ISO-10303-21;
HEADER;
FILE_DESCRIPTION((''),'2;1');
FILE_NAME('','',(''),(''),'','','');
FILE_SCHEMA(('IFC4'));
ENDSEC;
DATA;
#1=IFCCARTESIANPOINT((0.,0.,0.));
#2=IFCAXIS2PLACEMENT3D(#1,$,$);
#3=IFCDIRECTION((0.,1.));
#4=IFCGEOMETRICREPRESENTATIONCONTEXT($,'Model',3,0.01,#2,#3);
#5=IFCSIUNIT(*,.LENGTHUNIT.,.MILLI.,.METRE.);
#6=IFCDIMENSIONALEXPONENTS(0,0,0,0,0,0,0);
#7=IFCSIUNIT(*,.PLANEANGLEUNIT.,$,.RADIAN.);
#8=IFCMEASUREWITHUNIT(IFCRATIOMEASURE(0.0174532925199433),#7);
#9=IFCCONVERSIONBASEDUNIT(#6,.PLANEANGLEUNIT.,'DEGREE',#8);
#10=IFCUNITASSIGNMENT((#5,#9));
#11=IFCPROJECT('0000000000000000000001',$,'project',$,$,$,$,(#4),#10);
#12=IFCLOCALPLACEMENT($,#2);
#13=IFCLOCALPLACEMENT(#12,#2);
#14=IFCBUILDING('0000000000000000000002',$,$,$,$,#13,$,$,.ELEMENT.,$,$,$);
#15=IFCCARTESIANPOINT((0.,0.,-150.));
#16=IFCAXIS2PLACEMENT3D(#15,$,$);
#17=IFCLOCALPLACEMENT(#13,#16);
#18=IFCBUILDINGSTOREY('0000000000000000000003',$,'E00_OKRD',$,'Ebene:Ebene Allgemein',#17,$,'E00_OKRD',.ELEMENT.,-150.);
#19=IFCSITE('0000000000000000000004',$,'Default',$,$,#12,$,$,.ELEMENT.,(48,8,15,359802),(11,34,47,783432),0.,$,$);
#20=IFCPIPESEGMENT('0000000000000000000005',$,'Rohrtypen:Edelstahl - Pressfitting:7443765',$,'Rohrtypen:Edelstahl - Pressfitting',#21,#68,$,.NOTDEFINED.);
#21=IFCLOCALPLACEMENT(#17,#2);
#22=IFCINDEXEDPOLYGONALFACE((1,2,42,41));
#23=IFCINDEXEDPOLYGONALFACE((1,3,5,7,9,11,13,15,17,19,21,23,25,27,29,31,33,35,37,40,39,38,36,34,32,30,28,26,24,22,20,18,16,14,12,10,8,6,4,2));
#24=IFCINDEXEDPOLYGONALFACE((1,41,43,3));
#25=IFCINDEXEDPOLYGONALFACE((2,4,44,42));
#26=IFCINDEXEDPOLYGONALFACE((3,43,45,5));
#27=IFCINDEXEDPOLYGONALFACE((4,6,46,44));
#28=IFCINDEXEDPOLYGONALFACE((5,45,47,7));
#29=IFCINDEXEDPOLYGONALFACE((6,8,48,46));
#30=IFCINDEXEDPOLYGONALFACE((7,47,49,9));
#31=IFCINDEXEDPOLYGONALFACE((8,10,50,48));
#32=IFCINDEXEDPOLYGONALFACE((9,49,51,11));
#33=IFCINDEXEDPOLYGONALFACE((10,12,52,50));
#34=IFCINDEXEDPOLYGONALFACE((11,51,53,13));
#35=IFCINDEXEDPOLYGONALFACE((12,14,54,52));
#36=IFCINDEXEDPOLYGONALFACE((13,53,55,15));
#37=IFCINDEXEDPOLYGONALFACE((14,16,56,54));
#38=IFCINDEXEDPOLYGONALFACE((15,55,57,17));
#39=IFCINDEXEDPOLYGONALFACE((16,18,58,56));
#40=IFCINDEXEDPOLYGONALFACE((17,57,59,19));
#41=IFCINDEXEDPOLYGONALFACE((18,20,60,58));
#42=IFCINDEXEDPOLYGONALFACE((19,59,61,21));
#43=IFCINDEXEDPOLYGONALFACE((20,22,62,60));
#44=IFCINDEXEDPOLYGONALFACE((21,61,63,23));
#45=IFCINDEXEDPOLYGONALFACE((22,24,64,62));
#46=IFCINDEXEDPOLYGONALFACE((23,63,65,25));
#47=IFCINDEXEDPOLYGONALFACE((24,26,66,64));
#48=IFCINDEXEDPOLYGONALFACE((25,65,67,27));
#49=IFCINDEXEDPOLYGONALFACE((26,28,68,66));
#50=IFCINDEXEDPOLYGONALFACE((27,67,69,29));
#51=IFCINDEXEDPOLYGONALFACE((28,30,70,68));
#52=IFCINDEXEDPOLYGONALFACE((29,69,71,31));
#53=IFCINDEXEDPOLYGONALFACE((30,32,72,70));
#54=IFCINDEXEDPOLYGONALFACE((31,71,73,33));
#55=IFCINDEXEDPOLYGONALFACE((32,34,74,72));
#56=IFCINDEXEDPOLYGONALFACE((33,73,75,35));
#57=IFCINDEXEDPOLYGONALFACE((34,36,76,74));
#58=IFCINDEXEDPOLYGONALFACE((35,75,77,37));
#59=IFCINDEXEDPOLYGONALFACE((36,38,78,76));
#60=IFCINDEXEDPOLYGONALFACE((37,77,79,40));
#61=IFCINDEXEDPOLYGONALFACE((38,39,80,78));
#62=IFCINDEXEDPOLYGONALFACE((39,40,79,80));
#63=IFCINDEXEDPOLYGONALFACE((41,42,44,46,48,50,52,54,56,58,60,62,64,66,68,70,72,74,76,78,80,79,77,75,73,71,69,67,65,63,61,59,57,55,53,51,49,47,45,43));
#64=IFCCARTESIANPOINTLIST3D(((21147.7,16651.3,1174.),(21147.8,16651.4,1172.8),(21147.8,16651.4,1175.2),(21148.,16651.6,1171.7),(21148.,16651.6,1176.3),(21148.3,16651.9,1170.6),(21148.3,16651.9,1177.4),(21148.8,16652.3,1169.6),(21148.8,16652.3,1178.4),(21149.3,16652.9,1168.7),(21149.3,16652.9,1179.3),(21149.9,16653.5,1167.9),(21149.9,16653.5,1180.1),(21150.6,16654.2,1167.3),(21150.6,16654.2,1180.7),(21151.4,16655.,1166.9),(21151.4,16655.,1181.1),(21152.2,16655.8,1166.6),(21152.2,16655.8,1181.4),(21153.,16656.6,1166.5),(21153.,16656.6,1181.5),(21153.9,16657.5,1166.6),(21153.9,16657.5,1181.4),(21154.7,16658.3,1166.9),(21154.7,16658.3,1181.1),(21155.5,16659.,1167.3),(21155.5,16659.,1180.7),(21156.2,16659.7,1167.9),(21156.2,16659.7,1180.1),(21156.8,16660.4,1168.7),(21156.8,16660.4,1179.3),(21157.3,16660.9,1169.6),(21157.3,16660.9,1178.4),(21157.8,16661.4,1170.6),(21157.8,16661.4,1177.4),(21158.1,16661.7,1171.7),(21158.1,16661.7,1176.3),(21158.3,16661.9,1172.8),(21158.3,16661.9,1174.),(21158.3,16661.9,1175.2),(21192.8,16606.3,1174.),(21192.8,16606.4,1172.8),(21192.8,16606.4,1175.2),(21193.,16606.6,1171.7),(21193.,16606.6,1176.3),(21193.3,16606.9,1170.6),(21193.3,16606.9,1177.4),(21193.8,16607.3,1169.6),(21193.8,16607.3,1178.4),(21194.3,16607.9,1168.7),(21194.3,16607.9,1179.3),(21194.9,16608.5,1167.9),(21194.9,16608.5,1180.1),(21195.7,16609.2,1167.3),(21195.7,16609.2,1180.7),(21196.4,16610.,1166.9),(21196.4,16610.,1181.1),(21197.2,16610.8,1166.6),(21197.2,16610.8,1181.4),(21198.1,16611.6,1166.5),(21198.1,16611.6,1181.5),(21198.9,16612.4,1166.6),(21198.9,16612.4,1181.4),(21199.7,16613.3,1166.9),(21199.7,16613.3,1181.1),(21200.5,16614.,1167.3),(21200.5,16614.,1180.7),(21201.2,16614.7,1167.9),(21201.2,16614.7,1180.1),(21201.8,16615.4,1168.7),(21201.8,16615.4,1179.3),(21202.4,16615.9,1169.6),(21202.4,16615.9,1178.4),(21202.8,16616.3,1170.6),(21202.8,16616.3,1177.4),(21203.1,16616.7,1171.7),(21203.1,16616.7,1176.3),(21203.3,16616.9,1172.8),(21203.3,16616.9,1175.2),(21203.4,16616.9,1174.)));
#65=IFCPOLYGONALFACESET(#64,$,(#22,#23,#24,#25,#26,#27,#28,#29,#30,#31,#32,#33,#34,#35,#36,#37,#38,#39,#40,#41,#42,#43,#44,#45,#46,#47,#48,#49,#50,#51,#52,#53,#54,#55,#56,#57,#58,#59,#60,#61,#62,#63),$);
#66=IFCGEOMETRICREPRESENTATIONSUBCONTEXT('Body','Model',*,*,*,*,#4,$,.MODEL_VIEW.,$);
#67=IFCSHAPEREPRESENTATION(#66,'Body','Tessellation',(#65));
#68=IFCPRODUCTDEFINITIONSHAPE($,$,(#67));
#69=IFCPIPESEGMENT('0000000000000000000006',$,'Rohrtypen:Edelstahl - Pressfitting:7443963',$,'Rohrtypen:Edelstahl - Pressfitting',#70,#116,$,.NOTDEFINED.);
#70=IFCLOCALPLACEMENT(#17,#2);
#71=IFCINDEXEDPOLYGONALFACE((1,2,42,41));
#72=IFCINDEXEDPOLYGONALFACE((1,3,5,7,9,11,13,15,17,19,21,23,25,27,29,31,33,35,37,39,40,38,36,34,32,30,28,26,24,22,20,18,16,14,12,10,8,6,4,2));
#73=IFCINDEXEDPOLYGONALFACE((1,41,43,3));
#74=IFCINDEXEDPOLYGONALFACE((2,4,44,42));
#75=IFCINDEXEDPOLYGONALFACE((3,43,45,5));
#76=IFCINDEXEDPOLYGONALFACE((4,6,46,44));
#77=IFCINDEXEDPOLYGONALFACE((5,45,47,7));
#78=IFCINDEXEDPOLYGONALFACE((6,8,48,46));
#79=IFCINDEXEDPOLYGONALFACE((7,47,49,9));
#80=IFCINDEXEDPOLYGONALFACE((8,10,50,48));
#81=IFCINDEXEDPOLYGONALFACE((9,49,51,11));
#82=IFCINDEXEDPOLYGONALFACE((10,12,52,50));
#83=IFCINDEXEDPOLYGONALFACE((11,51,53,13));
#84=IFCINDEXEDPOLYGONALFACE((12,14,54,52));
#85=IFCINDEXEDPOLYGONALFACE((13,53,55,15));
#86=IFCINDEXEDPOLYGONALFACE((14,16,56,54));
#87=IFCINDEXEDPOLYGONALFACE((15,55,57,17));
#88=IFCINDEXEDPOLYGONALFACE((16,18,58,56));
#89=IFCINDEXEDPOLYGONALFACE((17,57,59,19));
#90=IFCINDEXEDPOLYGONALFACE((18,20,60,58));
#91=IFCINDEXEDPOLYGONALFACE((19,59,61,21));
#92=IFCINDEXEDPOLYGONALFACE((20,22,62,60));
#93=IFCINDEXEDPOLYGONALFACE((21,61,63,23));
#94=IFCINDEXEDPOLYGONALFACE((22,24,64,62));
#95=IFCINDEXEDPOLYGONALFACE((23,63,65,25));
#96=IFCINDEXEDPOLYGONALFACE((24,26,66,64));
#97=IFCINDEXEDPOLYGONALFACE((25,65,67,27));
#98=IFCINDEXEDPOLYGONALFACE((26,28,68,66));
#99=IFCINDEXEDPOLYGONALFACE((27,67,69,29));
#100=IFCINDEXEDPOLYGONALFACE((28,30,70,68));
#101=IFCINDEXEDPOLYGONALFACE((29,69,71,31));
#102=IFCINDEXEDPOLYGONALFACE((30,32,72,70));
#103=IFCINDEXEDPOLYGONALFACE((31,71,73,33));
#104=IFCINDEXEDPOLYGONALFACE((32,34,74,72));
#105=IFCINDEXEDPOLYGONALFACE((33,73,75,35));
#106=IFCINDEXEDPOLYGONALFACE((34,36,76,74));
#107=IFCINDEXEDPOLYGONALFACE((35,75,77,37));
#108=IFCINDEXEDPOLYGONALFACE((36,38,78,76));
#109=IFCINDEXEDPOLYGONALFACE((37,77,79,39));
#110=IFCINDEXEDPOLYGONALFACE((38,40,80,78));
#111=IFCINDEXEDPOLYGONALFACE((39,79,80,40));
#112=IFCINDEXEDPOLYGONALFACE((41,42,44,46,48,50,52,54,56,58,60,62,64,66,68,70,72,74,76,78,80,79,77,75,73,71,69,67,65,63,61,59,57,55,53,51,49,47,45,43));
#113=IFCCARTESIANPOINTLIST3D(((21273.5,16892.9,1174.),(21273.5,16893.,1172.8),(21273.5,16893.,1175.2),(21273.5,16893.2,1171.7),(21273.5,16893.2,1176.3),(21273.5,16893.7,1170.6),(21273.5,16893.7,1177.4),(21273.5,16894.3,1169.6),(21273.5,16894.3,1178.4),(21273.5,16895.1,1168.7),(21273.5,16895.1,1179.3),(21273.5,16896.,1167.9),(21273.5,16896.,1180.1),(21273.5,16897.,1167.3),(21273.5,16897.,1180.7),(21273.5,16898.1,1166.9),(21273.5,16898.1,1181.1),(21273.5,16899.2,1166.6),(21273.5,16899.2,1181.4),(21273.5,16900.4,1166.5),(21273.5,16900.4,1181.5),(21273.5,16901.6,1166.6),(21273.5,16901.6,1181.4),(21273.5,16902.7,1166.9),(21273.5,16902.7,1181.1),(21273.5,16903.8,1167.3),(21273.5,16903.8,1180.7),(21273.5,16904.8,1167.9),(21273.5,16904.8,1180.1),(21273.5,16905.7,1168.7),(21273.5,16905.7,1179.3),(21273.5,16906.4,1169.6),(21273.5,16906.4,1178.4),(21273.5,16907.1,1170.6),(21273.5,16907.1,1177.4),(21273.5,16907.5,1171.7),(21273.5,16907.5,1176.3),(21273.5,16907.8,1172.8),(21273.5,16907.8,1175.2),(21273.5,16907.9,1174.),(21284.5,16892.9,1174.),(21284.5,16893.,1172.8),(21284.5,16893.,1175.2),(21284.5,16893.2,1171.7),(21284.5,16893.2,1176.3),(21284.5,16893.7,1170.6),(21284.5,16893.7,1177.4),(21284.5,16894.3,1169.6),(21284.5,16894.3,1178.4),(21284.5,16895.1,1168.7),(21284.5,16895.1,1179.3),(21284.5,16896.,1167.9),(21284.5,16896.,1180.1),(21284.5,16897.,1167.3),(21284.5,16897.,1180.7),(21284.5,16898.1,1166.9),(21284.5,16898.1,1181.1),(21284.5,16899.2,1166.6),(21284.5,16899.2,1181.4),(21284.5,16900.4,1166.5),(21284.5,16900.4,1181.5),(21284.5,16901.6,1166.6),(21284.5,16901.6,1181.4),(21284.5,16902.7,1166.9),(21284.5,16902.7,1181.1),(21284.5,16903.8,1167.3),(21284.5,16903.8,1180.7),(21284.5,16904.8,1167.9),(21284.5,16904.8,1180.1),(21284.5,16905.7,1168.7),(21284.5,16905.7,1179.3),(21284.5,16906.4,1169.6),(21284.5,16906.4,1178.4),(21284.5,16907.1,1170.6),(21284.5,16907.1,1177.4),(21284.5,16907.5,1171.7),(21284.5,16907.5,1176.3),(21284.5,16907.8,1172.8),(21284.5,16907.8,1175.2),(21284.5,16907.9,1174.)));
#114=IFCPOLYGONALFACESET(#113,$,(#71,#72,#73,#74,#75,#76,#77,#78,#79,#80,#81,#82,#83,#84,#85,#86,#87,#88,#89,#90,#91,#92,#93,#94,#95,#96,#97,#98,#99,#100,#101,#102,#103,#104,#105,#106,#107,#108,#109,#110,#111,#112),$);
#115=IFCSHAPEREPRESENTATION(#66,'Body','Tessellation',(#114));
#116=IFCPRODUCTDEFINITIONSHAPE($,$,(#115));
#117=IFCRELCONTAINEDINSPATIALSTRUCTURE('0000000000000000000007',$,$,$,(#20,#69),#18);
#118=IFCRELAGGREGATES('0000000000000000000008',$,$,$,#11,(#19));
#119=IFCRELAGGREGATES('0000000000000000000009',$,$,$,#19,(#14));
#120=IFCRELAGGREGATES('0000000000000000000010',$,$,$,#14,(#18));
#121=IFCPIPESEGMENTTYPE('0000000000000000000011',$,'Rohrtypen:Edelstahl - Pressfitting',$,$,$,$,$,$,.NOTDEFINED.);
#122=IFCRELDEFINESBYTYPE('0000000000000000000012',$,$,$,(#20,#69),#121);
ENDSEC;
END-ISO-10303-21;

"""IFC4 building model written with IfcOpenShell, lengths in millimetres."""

from ifc_helpers import new_model, entity, si_unit, converted_unit, direction, frame, origin, place, context, subcontext, project, spatial, indexed_curve, outline, extrude, type_object, element, save


model = new_model("IFC4")

# Units and contexts
model_context = context("Model", 3, precision=0.01, world=origin(), true_north=direction((0.0, 1.0)))
body_context = subcontext(model_context, "Body", "Model", "MODEL_VIEW")
ifc_project = project(units=[si_unit("LENGTHUNIT", "METRE", prefix="MILLI"), converted_unit("PLANEANGLEUNIT", "DEGREE", entity("IfcRatioMeasure", 0.0174532925199433), si_unit("PLANEANGLEUNIT", "RADIAN"), dimensions=[0, 0, 0, 0, 0, 0, 0])], contexts=[model_context])

# Site, building, storey
site_placement = place(None, origin())
site = spatial("IfcSite", under=ifc_project, at=site_placement, Name="Default", CompositionType="ELEMENT", RefLatitude=(48, 8, 15, 359802), RefLongitude=(11, 34, 47, 783432), RefElevation=0.0)
building_placement = place(site_placement, origin())
building = spatial("IfcBuilding", under=site, at=building_placement, CompositionType="ELEMENT")
storey_placement = place(building_placement, frame((0.0, 0.0, -150.0)))
storey = spatial("IfcBuildingStorey", under=building, at=storey_placement, Name="E00_OKRD", ObjectType="Ebene:Ebene Allgemein", LongName="E00_OKRD", CompositionType="ELEMENT", Elevation=-150.0)

# Pipe segments
pipe_segment_type_1 = type_object("IfcPipeSegmentType", Name="Rohrtypen:Edelstahl - Pressfitting", PredefinedType="NOTDEFINED")
pipe_segment_1_placement = place(storey_placement, origin())
element("IfcPipeSegment", 1, at=pipe_segment_1_placement, inside=storey, type_object=pipe_segment_type_1, Name="Rohrtypen:Edelstahl - Pressfitting:7443765", ObjectType="Rohrtypen:Edelstahl - Pressfitting", PredefinedType="NOTDEFINED", context=body_context, shape_type="SweptSolid", body=[
    extrude(outline(indexed_curve([(7.5, 0.0), (7.4, 1.2), (7.1, 2.3), (6.7, 3.4), (6.1, 4.4), (5.3, 5.3), (4.4, 6.1), (3.4, 6.7), (2.3, 7.1), (1.2, 7.4), (0.0, 7.5), (-1.2, 7.4), (-2.3, 7.1), (-3.4, 6.7), (-4.4, 6.1), (-5.3, 5.3), (-6.1, 4.4), (-6.7, 3.4), (-7.1, 2.3), (-7.4, 1.2), (-7.5, 0.0), (-7.4, -1.2), (-7.1, -2.3), (-6.7, -3.4), (-6.1, -4.4), (-5.3, -5.3), (-4.4, -6.1), (-3.4, -6.7), (-2.3, -7.1), (-1.2, -7.4), (0.0, -7.5), (1.2, -7.4), (2.3, -7.1), (3.4, -6.7), (4.4, -6.1), (5.3, -5.3), (6.1, -4.4), (6.7, -3.4), (7.1, -2.3), (7.4, -1.2), (7.5, 0.0)], self_intersect=False)), frame((21153.0, 16656.6, 1174.0), z_axis=(0.707107, -0.707107, -0.000149), x_axis=(-0.707107, -0.707107, 0.0)), (0.0, 0.0, 1.0), 63.7),
])
pipe_segment_2_placement = place(storey_placement, origin())
element("IfcPipeSegment", 2, at=pipe_segment_2_placement, inside=storey, type_object=pipe_segment_type_1, Name="Rohrtypen:Edelstahl - Pressfitting:7443963", ObjectType="Rohrtypen:Edelstahl - Pressfitting", PredefinedType="NOTDEFINED", context=body_context, shape_type="SweptSolid", body=[
    extrude(outline(indexed_curve([(7.5, 0.0), (7.4, 1.2), (7.1, 2.3), (6.7, 3.4), (6.1, 4.4), (5.3, 5.3), (4.4, 6.1), (3.4, 6.7), (2.3, 7.1), (1.2, 7.4), (0.0, 7.5), (-1.2, 7.4), (-2.3, 7.1), (-3.4, 6.7), (-4.4, 6.1), (-5.3, 5.3), (-6.1, 4.4), (-6.7, 3.4), (-7.1, 2.3), (-7.4, 1.2), (-7.5, 0.0), (-7.4, -1.2), (-7.1, -2.3), (-6.7, -3.4), (-6.1, -4.4), (-5.3, -5.3), (-4.4, -6.1), (-3.4, -6.7), (-2.3, -7.1), (-1.2, -7.4), (0.0, -7.5), (1.2, -7.4), (2.3, -7.1), (3.4, -6.7), (4.4, -6.1), (5.3, -5.3), (6.1, -4.4), (6.7, -3.4), (7.1, -2.3), (7.4, -1.2), (7.5, 0.0)], self_intersect=False)), frame((21273.5, 16900.4, 1174.0), z_axis=(1.0, 0.0, 0.0), x_axis=(0.0, -1.0, 0.0)), (0.0, 0.0, 1.0), 11.1),
])

save(model, "model.ifc")
